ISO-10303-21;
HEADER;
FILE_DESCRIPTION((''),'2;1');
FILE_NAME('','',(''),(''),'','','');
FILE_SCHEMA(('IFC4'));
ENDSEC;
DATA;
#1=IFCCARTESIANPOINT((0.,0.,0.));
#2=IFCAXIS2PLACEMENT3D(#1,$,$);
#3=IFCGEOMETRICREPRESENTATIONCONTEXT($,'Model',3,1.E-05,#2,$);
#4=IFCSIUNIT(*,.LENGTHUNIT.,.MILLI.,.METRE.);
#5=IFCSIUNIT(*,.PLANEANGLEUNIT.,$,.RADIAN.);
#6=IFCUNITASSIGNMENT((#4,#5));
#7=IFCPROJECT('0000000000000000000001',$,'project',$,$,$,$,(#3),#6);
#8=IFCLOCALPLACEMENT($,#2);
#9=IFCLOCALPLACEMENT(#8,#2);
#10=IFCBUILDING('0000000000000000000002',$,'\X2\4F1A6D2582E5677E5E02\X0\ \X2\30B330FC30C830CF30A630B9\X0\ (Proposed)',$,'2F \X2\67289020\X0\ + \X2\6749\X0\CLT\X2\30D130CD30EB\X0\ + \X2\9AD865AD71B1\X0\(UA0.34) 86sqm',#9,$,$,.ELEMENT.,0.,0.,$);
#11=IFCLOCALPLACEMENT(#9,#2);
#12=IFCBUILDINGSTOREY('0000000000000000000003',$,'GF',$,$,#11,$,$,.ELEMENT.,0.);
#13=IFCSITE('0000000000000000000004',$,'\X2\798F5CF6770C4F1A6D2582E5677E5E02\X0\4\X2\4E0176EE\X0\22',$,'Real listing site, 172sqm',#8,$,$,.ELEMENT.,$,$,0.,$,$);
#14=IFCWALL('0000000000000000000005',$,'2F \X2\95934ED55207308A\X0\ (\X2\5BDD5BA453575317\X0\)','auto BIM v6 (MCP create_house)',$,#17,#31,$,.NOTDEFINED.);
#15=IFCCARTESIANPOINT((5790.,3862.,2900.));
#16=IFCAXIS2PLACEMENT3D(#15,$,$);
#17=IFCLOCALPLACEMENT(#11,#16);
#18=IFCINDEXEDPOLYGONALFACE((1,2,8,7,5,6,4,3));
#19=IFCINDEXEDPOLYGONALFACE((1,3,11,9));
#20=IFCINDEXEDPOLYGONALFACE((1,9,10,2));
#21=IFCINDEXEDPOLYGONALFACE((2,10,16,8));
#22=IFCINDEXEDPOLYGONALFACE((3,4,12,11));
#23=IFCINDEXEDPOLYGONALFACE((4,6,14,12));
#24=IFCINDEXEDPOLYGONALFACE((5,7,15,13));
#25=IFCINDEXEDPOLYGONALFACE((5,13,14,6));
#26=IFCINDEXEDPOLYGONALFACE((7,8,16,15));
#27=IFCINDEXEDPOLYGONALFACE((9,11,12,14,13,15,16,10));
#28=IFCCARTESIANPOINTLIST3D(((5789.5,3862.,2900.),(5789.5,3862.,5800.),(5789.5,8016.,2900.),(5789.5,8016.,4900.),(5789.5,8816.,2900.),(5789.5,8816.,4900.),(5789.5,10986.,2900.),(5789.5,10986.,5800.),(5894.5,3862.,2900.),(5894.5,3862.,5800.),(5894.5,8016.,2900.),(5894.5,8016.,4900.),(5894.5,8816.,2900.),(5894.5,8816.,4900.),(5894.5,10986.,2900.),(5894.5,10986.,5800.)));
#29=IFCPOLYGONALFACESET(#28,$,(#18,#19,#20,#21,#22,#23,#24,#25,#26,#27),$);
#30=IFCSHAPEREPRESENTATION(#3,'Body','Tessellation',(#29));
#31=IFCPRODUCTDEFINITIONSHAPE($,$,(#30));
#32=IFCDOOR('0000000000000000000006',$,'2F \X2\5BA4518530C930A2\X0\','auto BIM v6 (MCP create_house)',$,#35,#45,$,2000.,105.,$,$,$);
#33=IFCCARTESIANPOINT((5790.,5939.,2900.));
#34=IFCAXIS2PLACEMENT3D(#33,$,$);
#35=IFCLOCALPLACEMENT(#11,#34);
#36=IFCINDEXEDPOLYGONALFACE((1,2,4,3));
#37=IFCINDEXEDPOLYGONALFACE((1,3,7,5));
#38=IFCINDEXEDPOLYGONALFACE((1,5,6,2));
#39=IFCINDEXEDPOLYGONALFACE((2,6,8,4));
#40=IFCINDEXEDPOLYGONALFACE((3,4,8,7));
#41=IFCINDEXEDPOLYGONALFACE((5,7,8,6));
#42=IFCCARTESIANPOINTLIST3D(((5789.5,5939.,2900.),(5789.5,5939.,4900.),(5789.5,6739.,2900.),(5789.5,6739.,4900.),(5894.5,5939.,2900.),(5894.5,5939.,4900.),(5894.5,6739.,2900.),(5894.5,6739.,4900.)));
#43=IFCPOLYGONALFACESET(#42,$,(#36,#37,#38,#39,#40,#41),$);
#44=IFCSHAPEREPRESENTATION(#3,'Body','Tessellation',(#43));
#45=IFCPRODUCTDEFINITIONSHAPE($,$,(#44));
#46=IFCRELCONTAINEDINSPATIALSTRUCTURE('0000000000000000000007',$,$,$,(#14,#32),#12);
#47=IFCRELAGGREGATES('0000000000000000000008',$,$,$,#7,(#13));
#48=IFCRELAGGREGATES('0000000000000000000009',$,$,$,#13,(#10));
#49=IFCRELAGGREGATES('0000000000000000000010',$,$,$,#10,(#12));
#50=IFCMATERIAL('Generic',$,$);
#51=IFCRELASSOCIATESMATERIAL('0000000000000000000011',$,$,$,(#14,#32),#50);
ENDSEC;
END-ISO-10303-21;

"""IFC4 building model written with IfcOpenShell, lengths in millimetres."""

from ifc_helpers import new_model, si_unit, frame, frame_2d, origin, place, context, project, spatial, rectangle, extrude, material, element, fill, save


model = new_model("IFC4")

# Units and contexts
model_context = context("Model", 3, precision=1e-05, world=origin())
ifc_project = project(units=[si_unit("LENGTHUNIT", "METRE", prefix="MILLI"), si_unit("PLANEANGLEUNIT", "RADIAN")], contexts=[model_context])

# Site, building, storey
site_placement = place(None, origin())
site = spatial("IfcSite", under=ifc_project, at=site_placement, Name="福島県会津若松市4丁目22", ObjectType="Real listing site, 172sqm", CompositionType="ELEMENT", RefElevation=0.0)
building_placement = place(site_placement, origin())
building = spatial("IfcBuilding", under=site, at=building_placement, Name="会津若松市 コートハウス (Proposed)", ObjectType="2F 木造 + 杉CLTパネル + 高断熱(UA0.34) 86sqm", CompositionType="ELEMENT", ElevationOfRefHeight=0.0, ElevationOfTerrain=0.0)
storey_placement = place(building_placement, origin())
storey = spatial("IfcBuildingStorey", under=building, at=storey_placement, Name="GF", CompositionType="ELEMENT", Elevation=0.0)

# Shared definitions
ifc_material = material(Name="Generic")

# Wall, opening, door
wall_1_placement = place(storey_placement, frame((5790.0, 3862.0, 2900.0)))
wall_1 = element("IfcWall", 1, at=wall_1_placement, inside=storey, material=ifc_material, Name="2F 間仕切り (寝室南北)", Description="auto BIM v6 (MCP create_house)", PredefinedType="NOTDEFINED", context=model_context, shape_type="SweptSolid", body=[
    extrude(rectangle(XDim=105.0, YDim=7124.0, at=frame_2d((52.0, 3562.0))), frame((5790.0, 3862.0, 2900.0)), (0.0, 0.0, 1.0), 2900.0),
])
opening_1_placement = place(storey_placement, frame((5790.0, 5939.0, 2900.0)))
opening_1 = element("IfcOpeningElement", 2, at=opening_1_placement, cuts=wall_1, PredefinedType="NOTDEFINED", context=model_context, shape_type="SweptSolid", body=[
    extrude(rectangle(XDim=105.0, YDim=800.0, at=frame_2d((52.0, 400.0))), frame((5790.0, 5939.0, 2900.0)), (0.0, 0.0, 1.0), 2000.0),
])
door_placement = place(storey_placement, frame((5790.0, 5939.0, 2900.0)))
door = element("IfcDoor", 3, at=door_placement, inside=storey, material=ifc_material, Name="2F 室内ドア", Description="auto BIM v6 (MCP create_house)", OverallHeight=2000.0, OverallWidth=105.0, context=model_context, shape_type="SweptSolid", body=[
    extrude(rectangle(XDim=105.0, YDim=800.0, at=frame_2d((52.0, 400.0))), frame((5790.0, 5939.0, 2900.0)), (0.0, 0.0, 1.0), 2000.0),
])
fill(opening_1, door)

save(model, "model.ifc")
